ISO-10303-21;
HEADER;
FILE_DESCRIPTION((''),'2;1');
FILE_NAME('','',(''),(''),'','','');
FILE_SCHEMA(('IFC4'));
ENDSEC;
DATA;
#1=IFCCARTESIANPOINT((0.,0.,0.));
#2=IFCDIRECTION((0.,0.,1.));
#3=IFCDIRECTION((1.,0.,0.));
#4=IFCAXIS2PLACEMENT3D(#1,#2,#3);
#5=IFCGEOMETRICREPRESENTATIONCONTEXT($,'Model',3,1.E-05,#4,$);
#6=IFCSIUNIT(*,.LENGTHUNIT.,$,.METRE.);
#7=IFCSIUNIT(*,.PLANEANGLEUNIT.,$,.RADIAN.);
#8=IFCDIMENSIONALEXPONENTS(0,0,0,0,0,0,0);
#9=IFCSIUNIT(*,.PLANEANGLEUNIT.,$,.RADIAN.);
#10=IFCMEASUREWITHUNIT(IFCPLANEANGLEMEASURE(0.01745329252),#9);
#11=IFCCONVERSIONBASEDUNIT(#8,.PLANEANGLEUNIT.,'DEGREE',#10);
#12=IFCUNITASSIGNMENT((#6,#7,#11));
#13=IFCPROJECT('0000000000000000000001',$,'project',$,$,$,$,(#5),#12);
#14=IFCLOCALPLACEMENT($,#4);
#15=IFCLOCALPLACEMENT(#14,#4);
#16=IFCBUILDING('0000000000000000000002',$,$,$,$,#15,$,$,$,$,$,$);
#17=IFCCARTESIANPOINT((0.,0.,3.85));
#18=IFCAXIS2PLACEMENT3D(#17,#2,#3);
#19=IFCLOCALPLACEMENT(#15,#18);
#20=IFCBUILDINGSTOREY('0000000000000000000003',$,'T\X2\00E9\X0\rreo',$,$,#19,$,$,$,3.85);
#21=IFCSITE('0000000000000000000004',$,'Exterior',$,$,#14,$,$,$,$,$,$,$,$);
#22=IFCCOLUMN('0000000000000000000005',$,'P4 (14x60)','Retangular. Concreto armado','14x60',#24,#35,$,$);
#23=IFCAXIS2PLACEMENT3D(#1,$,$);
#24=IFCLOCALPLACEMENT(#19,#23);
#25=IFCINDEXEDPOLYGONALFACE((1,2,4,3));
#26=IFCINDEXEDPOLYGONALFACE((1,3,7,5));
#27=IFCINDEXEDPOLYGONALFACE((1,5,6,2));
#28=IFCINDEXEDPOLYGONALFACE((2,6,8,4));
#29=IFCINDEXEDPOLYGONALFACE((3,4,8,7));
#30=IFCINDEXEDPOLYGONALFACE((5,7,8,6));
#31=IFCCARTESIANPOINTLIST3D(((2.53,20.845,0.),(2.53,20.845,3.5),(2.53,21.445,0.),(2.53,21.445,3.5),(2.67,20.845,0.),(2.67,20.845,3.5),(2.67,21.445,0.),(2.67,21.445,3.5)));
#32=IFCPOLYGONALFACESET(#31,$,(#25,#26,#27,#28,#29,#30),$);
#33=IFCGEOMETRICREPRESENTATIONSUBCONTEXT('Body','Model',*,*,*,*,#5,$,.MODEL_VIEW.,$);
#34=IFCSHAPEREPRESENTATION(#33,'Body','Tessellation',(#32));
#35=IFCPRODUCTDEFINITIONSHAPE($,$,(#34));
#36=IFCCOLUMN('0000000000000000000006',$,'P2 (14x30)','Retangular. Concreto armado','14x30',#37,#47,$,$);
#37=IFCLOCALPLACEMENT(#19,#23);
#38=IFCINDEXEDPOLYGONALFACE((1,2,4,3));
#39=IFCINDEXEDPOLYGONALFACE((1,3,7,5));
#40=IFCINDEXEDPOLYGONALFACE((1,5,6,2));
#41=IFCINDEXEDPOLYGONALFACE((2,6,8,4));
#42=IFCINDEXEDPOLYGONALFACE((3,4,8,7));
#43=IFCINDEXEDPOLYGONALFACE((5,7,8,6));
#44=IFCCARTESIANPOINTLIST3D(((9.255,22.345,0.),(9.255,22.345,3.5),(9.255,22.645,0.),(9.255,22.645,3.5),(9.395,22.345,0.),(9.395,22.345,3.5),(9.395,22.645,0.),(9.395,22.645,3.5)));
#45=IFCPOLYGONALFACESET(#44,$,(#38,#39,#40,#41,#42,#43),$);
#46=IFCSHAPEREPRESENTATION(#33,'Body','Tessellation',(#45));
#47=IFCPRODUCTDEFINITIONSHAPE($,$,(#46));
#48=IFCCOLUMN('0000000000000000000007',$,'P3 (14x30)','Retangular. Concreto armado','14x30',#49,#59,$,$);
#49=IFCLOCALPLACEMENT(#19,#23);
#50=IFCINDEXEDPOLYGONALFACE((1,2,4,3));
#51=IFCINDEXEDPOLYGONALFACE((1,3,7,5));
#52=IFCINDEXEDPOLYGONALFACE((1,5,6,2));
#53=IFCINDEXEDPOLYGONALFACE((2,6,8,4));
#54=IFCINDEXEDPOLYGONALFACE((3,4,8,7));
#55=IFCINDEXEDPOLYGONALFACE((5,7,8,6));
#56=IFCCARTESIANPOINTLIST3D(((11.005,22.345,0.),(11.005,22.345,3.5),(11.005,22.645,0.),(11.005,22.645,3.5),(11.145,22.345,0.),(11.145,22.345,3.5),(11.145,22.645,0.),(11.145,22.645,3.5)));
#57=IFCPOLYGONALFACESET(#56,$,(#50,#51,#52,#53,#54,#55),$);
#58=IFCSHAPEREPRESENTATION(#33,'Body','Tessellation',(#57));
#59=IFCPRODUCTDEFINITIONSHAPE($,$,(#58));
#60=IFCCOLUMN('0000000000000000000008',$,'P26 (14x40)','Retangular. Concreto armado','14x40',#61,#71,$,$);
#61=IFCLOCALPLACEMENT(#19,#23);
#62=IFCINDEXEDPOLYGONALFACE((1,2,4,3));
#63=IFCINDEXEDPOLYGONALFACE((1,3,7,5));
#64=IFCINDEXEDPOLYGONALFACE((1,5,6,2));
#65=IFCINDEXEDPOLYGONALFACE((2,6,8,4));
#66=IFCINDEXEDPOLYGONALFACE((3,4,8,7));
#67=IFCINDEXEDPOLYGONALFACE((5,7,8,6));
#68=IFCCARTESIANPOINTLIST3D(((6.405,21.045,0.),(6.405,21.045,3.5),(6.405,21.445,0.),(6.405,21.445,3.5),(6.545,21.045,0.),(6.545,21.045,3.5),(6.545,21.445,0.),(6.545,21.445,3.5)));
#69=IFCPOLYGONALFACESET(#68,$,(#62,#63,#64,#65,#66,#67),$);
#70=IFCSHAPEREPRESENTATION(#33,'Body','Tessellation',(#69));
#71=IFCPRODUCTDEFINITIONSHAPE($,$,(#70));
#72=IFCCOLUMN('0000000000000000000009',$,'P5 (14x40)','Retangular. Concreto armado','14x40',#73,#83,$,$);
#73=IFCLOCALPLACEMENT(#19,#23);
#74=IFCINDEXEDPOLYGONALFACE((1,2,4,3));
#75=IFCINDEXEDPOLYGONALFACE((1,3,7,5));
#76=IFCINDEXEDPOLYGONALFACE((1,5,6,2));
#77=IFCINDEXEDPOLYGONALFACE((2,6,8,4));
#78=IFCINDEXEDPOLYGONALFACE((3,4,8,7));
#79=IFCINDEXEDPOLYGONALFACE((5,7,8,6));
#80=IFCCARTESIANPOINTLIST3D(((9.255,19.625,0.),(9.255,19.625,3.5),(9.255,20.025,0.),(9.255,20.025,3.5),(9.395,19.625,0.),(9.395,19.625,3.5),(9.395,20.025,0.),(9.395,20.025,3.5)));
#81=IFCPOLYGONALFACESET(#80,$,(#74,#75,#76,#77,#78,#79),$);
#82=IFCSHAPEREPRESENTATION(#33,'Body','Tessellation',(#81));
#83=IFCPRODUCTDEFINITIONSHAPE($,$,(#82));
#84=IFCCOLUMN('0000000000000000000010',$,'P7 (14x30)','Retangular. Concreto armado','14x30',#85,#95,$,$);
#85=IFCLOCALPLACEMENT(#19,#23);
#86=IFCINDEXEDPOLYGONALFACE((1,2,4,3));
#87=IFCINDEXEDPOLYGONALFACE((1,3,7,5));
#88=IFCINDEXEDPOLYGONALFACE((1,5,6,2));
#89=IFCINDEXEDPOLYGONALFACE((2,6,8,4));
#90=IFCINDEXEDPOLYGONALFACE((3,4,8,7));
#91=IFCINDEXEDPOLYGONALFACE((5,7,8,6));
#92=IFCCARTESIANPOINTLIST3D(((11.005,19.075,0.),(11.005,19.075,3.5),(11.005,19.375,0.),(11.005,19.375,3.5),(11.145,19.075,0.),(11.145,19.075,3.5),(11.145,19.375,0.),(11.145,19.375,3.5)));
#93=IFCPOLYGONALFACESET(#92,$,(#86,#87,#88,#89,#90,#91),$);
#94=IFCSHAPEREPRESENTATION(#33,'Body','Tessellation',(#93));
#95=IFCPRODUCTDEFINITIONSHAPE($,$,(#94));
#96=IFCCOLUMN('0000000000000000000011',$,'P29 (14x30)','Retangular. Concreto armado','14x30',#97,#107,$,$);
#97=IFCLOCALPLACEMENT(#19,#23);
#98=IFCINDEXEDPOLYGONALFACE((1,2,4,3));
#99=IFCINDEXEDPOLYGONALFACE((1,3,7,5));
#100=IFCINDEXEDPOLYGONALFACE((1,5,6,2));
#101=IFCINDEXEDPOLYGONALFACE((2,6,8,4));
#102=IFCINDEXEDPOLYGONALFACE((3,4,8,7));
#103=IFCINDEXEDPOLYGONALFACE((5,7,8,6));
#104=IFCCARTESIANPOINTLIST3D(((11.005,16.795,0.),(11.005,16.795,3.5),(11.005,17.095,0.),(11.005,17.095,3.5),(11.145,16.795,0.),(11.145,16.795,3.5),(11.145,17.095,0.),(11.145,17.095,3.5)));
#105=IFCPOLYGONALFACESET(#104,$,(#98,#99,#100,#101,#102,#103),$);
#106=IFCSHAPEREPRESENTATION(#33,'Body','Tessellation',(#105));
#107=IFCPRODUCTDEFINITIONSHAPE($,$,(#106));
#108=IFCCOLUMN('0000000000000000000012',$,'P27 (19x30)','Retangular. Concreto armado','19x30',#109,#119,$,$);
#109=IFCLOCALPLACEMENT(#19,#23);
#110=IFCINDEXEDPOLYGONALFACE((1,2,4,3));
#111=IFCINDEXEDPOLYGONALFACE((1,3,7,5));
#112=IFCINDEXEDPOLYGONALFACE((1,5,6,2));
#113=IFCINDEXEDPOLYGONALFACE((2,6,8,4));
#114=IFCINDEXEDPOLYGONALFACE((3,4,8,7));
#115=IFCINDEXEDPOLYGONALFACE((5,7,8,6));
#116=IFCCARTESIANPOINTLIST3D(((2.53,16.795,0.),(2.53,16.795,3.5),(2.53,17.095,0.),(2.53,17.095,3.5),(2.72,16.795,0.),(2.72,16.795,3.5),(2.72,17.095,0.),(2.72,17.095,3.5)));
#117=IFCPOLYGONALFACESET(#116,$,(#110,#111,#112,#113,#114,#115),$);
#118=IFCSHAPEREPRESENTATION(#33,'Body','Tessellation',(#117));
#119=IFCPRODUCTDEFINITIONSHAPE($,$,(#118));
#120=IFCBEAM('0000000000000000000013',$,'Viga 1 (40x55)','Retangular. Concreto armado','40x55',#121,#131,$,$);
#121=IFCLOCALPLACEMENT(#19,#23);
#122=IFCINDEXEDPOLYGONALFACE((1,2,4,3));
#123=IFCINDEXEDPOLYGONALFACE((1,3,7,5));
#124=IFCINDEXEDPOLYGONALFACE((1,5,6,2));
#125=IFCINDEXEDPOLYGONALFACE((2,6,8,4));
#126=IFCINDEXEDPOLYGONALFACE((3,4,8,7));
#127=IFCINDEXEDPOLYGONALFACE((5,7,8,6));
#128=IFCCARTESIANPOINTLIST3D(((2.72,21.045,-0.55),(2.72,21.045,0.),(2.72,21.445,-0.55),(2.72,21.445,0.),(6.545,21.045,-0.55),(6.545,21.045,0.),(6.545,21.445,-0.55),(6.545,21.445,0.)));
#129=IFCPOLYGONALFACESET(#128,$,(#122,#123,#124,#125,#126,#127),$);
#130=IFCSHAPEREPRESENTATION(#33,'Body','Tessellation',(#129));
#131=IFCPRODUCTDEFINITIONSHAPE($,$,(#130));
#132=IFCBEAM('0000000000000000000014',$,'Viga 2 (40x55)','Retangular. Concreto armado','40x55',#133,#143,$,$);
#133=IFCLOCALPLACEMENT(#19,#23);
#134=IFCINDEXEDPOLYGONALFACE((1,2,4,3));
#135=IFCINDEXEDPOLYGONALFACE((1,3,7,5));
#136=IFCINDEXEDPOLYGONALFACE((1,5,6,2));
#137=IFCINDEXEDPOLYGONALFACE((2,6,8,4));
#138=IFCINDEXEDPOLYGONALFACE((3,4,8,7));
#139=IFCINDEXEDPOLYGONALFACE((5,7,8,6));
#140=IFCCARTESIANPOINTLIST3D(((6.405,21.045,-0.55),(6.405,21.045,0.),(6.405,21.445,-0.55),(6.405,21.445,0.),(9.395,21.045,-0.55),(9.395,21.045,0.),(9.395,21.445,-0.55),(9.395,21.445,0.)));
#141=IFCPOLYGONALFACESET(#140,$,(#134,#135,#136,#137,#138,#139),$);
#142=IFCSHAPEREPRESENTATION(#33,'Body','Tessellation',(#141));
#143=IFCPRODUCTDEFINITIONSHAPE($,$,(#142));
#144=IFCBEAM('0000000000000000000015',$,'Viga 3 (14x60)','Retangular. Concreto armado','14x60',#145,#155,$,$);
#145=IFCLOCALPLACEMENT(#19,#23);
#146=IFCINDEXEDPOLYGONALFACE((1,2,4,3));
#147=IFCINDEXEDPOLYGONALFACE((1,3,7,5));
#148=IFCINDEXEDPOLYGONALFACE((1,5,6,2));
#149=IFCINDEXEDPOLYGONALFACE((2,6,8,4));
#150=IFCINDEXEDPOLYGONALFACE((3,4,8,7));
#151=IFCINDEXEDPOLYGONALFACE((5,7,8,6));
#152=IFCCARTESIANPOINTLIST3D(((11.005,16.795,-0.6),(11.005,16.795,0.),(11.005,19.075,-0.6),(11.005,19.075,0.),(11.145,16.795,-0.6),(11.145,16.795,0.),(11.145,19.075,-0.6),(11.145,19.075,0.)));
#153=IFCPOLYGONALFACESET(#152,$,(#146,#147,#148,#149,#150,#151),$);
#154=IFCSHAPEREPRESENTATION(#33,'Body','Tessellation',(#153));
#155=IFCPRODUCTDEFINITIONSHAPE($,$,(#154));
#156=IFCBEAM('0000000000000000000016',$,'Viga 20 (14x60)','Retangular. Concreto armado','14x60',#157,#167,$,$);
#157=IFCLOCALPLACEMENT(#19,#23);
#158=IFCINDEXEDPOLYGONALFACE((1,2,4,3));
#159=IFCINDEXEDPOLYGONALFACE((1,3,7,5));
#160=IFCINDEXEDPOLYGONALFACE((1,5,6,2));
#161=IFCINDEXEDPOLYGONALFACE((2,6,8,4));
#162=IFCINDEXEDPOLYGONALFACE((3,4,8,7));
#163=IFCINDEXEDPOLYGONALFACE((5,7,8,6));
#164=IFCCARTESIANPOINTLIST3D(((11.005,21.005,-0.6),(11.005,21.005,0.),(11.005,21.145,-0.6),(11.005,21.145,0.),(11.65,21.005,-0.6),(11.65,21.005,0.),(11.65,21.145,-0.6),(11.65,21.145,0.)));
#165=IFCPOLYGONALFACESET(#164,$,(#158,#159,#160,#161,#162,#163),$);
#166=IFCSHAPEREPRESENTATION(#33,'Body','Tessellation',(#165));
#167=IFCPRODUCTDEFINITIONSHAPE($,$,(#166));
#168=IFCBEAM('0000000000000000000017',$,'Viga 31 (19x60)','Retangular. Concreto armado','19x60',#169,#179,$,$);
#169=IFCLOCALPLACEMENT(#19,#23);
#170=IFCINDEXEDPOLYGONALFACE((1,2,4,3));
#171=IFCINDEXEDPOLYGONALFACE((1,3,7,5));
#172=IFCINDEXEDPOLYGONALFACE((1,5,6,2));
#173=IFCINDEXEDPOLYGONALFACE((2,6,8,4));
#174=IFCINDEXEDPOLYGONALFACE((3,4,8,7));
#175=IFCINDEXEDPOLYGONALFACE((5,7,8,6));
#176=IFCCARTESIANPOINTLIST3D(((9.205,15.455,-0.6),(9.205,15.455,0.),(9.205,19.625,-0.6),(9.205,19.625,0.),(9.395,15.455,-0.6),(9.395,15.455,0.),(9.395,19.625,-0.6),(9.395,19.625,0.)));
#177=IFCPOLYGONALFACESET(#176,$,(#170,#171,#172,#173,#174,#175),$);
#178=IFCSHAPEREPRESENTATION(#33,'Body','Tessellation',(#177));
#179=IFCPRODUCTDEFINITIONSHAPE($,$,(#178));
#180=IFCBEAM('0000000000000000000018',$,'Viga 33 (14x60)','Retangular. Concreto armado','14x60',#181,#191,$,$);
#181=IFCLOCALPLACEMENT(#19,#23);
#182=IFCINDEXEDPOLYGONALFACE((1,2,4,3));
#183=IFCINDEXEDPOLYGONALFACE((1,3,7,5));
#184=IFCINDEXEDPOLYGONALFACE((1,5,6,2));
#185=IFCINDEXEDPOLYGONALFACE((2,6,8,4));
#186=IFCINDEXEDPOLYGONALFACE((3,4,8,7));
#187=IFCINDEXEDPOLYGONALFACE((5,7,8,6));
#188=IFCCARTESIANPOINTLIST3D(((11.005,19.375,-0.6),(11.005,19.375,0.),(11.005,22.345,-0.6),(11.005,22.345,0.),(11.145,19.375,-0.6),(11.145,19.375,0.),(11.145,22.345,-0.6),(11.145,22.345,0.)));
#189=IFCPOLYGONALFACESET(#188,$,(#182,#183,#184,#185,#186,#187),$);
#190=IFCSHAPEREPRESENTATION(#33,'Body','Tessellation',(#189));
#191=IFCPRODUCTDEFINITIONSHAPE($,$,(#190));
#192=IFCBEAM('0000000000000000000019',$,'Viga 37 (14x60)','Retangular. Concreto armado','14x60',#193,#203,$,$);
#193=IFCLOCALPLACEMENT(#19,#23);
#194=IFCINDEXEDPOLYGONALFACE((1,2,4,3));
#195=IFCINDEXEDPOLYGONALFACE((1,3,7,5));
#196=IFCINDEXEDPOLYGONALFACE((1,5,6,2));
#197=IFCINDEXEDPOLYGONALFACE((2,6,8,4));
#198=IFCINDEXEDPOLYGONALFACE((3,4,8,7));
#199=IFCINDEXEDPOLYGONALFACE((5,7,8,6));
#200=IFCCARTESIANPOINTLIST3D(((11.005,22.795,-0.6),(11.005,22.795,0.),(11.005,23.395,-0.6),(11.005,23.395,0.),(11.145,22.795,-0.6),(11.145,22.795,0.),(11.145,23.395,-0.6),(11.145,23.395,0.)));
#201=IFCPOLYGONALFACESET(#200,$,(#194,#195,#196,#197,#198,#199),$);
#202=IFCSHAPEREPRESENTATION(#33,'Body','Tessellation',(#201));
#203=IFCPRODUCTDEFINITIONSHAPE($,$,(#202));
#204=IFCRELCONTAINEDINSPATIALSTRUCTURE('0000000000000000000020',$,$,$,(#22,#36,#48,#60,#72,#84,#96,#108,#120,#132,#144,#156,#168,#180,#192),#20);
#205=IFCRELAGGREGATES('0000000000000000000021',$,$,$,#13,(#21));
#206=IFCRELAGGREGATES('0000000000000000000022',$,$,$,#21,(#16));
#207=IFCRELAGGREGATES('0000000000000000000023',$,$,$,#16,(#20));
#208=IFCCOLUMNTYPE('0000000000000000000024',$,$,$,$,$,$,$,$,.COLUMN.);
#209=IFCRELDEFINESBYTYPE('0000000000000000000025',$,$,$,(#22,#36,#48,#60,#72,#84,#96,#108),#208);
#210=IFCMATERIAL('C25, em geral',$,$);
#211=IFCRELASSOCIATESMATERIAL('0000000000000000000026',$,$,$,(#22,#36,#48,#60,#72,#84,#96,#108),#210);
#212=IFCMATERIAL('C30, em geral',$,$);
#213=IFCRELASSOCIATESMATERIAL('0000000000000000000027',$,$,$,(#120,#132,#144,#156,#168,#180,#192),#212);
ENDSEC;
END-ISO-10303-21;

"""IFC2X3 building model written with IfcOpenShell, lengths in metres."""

from ifc_helpers import new_model, entity, si_unit, converted_unit, frame, frame_2d, origin_with_axes, place, context, subcontext, project, spatial, rectangle, extrude, material, type_object, element, save


model = new_model("IFC2X3")

# Units and contexts
model_context = context("Model", 3, precision=1e-05, world=origin_with_axes())
body_context = subcontext(model_context, "Body", "Model", "MODEL_VIEW")
ifc_project = project(units=[si_unit("LENGTHUNIT", "METRE"), si_unit("PLANEANGLEUNIT", "RADIAN"), converted_unit("PLANEANGLEUNIT", "DEGREE", entity("IfcPlaneAngleMeasure", 0.01745329252), si_unit("PLANEANGLEUNIT", "RADIAN"), dimensions=[0, 0, 0, 0, 0, 0, 0])], contexts=[model_context])

# Site, building, storey
site_placement = place(None, origin_with_axes())
site = spatial("IfcSite", under=ifc_project, at=site_placement, Name="Exterior")
building_placement = place(site_placement, origin_with_axes())
building = spatial("IfcBuilding", under=site, at=building_placement)
storey_placement = place(building_placement, frame((0.0, 0.0, 3.85), z_axis=(0.0, 0.0, 1.0), x_axis=(1.0, 0.0, 0.0)))
storey = spatial("IfcBuildingStorey", under=building, at=storey_placement, Name="Térreo", Elevation=3.85)

# Columns
ifc_material_1 = material(Name="C25, em geral")
column_type = type_object("IfcColumnType", PredefinedType="COLUMN")
column_1_placement = place(storey_placement, frame((2.53, 21.445, 0.0), z_axis=(0.0, 0.0, 1.0), x_axis=(1.0, 0.0, 0.0)))
element("IfcColumn", 1, at=column_1_placement, inside=storey, type_object=column_type, material=ifc_material_1, Name="P4 (14x60)", Description="Retangular. Concreto armado", ObjectType="14x60", context=body_context, shape_type="SweptSolid", body=[
    extrude(rectangle(XDim=0.14, YDim=0.6, at=frame_2d((0.07, -0.3), x_axis=(1.0, 0.0))), origin_with_axes(), (0.0, 0.0, 1.0), 3.5),
])
for number, where, z_axis, x_axis, name in (
    (2, (9.395, 22.345, 0.0), (0.0, 0.0, 1.0), (1.0, 0.0, 0.0), "P2 (14x30)"),
    (3, (11.145, 22.345, 0.0), (0.0, 0.0, 1.0), (1.0, 0.0, 0.0), "P3 (14x30)"),
):
    element("IfcColumn", number, at=place(storey_placement, frame(where, z_axis=z_axis, x_axis=x_axis)), inside=storey, type_object=column_type, material=ifc_material_1, Name=name, Description="Retangular. Concreto armado", ObjectType="14x30", context=body_context, shape_type="SweptSolid", body=[
        extrude(rectangle(XDim=0.14, YDim=0.3, at=frame_2d((-0.07, 0.15), x_axis=(1.0, 0.0))), origin_with_axes(), (0.0, 0.0, 1.0), 3.5),
    ])
column_2_placement = place(storey_placement, frame((6.545, 21.445, 0.0), z_axis=(0.0, 0.0, 1.0), x_axis=(1.0, 0.0, 0.0)))
element("IfcColumn", 4, at=column_2_placement, inside=storey, type_object=column_type, material=ifc_material_1, Name="P26 (14x40)", Description="Retangular. Concreto armado", ObjectType="14x40", context=body_context, shape_type="SweptSolid", body=[
    extrude(rectangle(XDim=0.14, YDim=0.4, at=frame_2d((-0.07, -0.2), x_axis=(1.0, 0.0))), origin_with_axes(), (0.0, 0.0, 1.0), 3.5),
])
column_3_placement = place(storey_placement, frame((9.395, 19.625, 0.0), z_axis=(0.0, 0.0, 1.0), x_axis=(1.0, 0.0, 0.0)))
element("IfcColumn", 5, at=column_3_placement, inside=storey, type_object=column_type, material=ifc_material_1, Name="P5 (14x40)", Description="Retangular. Concreto armado", ObjectType="14x40", context=body_context, shape_type="SweptSolid", body=[
    extrude(rectangle(XDim=0.14, YDim=0.4, at=frame_2d((-0.07, 0.2), x_axis=(1.0, 0.0))), origin_with_axes(), (0.0, 0.0, 1.0), 3.5),
])
for number, where, z_axis, x_axis, name in (
    (6, (11.005, 19.375, 0.0), (0.0, 0.0, 1.0), (1.0, 0.0, 0.0), "P7 (14x30)"),
    (7, (11.005, 17.095, 0.0), (0.0, 0.0, 1.0), (1.0, 0.0, 0.0), "P29 (14x30)"),
):
    element("IfcColumn", number, at=place(storey_placement, frame(where, z_axis=z_axis, x_axis=x_axis)), inside=storey, type_object=column_type, material=ifc_material_1, Name=name, Description="Retangular. Concreto armado", ObjectType="14x30", context=body_context, shape_type="SweptSolid", body=[
        extrude(rectangle(XDim=0.14, YDim=0.3, at=frame_2d((0.07, -0.15), x_axis=(1.0, 0.0))), origin_with_axes(), (0.0, 0.0, 1.0), 3.5),
    ])
column_4_placement = place(storey_placement, frame((2.53, 17.095, 0.0), z_axis=(0.0, 0.0, 1.0), x_axis=(1.0, 0.0, 0.0)))
element("IfcColumn", 8, at=column_4_placement, inside=storey, type_object=column_type, material=ifc_material_1, Name="P27 (19x30)", Description="Retangular. Concreto armado", ObjectType="19x30", context=body_context, shape_type="SweptSolid", body=[
    extrude(rectangle(XDim=0.19, YDim=0.3, at=frame_2d((0.095, -0.15), x_axis=(1.0, 0.0))), origin_with_axes(), (0.0, 0.0, 1.0), 3.5),
])

# Beams
ifc_material_2 = material(Name="C30, em geral")
beam_1_placement = place(storey_placement, frame((2.72, 21.245, 0.0), z_axis=(1.0, 0.0, 0.0), x_axis=(0.0, 1.0, 0.0)))
element("IfcBeam", 9, at=beam_1_placement, inside=storey, material=ifc_material_2, Name="Viga 1 (40x55)", Description="Retangular. Concreto armado", ObjectType="40x55", context=body_context, shape_type="SweptSolid", body=[
    extrude(rectangle(XDim=0.4, YDim=0.55, at=frame_2d((0.0, -0.275), x_axis=(1.0, 0.0))), origin_with_axes(), (0.0, 0.0, 1.0), 3.825),
])
beam_2_placement = place(storey_placement, frame((6.405, 21.245, 0.0), z_axis=(1.0, 0.0, 0.0), x_axis=(0.0, 1.0, 0.0)))
element("IfcBeam", 10, at=beam_2_placement, inside=storey, material=ifc_material_2, Name="Viga 2 (40x55)", Description="Retangular. Concreto armado", ObjectType="40x55", context=body_context, shape_type="SweptSolid", body=[
    extrude(rectangle(XDim=0.4, YDim=0.55, at=frame_2d((0.0, -0.275), x_axis=(1.0, 0.0))), origin_with_axes(), (0.0, 0.0, 1.0), 2.99),
])
beam_3_placement = place(storey_placement, frame((11.075, 19.075, 0.0), z_axis=(0.0, -1.0, 0.0), x_axis=(1.0, 0.0, 0.0)))
element("IfcBeam", 11, at=beam_3_placement, inside=storey, material=ifc_material_2, Name="Viga 3 (14x60)", Description="Retangular. Concreto armado", ObjectType="14x60", context=body_context, shape_type="SweptSolid", body=[
    extrude(rectangle(XDim=0.14, YDim=0.6, at=frame_2d((0.0, -0.3), x_axis=(1.0, 0.0))), origin_with_axes(), (0.0, 0.0, 1.0), 2.28),
])
beam_4_placement = place(storey_placement, frame((11.005, 21.075, 0.0), z_axis=(1.0, 0.0, 0.0), x_axis=(0.0, 1.0, 0.0)))
element("IfcBeam", 12, at=beam_4_placement, inside=storey, material=ifc_material_2, Name="Viga 20 (14x60)", Description="Retangular. Concreto armado", ObjectType="14x60", context=body_context, shape_type="SweptSolid", body=[
    extrude(rectangle(XDim=0.14, YDim=0.6, at=frame_2d((0.0, -0.3), x_axis=(1.0, 0.0))), origin_with_axes(), (0.0, 0.0, 1.0), 0.645),
])
beam_5_placement = place(storey_placement, frame((9.3, 19.625, 0.0), z_axis=(0.0, -1.0, 0.0), x_axis=(1.0, 0.0, 0.0)))
element("IfcBeam", 13, at=beam_5_placement, inside=storey, material=ifc_material_2, Name="Viga 31 (19x60)", Description="Retangular. Concreto armado", ObjectType="19x60", context=body_context, shape_type="SweptSolid", body=[
    extrude(rectangle(XDim=0.19, YDim=0.6, at=frame_2d((0.0, -0.3), x_axis=(1.0, 0.0))), origin_with_axes(), (0.0, 0.0, 1.0), 4.17),
])
beam_6_placement = place(storey_placement, frame((11.075, 19.375, 0.0), z_axis=(0.0, 1.0, 0.0), x_axis=(-1.0, 0.0, 0.0)))
element("IfcBeam", 14, at=beam_6_placement, inside=storey, material=ifc_material_2, Name="Viga 33 (14x60)", Description="Retangular. Concreto armado", ObjectType="14x60", context=body_context, shape_type="SweptSolid", body=[
    extrude(rectangle(XDim=0.14, YDim=0.6, at=frame_2d((0.0, -0.3), x_axis=(1.0, 0.0))), origin_with_axes(), (0.0, 0.0, 1.0), 2.97),
])
beam_7_placement = place(storey_placement, frame((11.075, 22.795, 0.0), z_axis=(0.0, 1.0, 0.0), x_axis=(-1.0, 0.0, 0.0)))
element("IfcBeam", 15, at=beam_7_placement, inside=storey, material=ifc_material_2, Name="Viga 37 (14x60)", Description="Retangular. Concreto armado", ObjectType="14x60", context=body_context, shape_type="SweptSolid", body=[
    extrude(rectangle(XDim=0.14, YDim=0.6, at=frame_2d((0.0, -0.3), x_axis=(1.0, 0.0))), origin_with_axes(), (0.0, 0.0, 1.0), 0.6),
])

save(model, "model.ifc")
